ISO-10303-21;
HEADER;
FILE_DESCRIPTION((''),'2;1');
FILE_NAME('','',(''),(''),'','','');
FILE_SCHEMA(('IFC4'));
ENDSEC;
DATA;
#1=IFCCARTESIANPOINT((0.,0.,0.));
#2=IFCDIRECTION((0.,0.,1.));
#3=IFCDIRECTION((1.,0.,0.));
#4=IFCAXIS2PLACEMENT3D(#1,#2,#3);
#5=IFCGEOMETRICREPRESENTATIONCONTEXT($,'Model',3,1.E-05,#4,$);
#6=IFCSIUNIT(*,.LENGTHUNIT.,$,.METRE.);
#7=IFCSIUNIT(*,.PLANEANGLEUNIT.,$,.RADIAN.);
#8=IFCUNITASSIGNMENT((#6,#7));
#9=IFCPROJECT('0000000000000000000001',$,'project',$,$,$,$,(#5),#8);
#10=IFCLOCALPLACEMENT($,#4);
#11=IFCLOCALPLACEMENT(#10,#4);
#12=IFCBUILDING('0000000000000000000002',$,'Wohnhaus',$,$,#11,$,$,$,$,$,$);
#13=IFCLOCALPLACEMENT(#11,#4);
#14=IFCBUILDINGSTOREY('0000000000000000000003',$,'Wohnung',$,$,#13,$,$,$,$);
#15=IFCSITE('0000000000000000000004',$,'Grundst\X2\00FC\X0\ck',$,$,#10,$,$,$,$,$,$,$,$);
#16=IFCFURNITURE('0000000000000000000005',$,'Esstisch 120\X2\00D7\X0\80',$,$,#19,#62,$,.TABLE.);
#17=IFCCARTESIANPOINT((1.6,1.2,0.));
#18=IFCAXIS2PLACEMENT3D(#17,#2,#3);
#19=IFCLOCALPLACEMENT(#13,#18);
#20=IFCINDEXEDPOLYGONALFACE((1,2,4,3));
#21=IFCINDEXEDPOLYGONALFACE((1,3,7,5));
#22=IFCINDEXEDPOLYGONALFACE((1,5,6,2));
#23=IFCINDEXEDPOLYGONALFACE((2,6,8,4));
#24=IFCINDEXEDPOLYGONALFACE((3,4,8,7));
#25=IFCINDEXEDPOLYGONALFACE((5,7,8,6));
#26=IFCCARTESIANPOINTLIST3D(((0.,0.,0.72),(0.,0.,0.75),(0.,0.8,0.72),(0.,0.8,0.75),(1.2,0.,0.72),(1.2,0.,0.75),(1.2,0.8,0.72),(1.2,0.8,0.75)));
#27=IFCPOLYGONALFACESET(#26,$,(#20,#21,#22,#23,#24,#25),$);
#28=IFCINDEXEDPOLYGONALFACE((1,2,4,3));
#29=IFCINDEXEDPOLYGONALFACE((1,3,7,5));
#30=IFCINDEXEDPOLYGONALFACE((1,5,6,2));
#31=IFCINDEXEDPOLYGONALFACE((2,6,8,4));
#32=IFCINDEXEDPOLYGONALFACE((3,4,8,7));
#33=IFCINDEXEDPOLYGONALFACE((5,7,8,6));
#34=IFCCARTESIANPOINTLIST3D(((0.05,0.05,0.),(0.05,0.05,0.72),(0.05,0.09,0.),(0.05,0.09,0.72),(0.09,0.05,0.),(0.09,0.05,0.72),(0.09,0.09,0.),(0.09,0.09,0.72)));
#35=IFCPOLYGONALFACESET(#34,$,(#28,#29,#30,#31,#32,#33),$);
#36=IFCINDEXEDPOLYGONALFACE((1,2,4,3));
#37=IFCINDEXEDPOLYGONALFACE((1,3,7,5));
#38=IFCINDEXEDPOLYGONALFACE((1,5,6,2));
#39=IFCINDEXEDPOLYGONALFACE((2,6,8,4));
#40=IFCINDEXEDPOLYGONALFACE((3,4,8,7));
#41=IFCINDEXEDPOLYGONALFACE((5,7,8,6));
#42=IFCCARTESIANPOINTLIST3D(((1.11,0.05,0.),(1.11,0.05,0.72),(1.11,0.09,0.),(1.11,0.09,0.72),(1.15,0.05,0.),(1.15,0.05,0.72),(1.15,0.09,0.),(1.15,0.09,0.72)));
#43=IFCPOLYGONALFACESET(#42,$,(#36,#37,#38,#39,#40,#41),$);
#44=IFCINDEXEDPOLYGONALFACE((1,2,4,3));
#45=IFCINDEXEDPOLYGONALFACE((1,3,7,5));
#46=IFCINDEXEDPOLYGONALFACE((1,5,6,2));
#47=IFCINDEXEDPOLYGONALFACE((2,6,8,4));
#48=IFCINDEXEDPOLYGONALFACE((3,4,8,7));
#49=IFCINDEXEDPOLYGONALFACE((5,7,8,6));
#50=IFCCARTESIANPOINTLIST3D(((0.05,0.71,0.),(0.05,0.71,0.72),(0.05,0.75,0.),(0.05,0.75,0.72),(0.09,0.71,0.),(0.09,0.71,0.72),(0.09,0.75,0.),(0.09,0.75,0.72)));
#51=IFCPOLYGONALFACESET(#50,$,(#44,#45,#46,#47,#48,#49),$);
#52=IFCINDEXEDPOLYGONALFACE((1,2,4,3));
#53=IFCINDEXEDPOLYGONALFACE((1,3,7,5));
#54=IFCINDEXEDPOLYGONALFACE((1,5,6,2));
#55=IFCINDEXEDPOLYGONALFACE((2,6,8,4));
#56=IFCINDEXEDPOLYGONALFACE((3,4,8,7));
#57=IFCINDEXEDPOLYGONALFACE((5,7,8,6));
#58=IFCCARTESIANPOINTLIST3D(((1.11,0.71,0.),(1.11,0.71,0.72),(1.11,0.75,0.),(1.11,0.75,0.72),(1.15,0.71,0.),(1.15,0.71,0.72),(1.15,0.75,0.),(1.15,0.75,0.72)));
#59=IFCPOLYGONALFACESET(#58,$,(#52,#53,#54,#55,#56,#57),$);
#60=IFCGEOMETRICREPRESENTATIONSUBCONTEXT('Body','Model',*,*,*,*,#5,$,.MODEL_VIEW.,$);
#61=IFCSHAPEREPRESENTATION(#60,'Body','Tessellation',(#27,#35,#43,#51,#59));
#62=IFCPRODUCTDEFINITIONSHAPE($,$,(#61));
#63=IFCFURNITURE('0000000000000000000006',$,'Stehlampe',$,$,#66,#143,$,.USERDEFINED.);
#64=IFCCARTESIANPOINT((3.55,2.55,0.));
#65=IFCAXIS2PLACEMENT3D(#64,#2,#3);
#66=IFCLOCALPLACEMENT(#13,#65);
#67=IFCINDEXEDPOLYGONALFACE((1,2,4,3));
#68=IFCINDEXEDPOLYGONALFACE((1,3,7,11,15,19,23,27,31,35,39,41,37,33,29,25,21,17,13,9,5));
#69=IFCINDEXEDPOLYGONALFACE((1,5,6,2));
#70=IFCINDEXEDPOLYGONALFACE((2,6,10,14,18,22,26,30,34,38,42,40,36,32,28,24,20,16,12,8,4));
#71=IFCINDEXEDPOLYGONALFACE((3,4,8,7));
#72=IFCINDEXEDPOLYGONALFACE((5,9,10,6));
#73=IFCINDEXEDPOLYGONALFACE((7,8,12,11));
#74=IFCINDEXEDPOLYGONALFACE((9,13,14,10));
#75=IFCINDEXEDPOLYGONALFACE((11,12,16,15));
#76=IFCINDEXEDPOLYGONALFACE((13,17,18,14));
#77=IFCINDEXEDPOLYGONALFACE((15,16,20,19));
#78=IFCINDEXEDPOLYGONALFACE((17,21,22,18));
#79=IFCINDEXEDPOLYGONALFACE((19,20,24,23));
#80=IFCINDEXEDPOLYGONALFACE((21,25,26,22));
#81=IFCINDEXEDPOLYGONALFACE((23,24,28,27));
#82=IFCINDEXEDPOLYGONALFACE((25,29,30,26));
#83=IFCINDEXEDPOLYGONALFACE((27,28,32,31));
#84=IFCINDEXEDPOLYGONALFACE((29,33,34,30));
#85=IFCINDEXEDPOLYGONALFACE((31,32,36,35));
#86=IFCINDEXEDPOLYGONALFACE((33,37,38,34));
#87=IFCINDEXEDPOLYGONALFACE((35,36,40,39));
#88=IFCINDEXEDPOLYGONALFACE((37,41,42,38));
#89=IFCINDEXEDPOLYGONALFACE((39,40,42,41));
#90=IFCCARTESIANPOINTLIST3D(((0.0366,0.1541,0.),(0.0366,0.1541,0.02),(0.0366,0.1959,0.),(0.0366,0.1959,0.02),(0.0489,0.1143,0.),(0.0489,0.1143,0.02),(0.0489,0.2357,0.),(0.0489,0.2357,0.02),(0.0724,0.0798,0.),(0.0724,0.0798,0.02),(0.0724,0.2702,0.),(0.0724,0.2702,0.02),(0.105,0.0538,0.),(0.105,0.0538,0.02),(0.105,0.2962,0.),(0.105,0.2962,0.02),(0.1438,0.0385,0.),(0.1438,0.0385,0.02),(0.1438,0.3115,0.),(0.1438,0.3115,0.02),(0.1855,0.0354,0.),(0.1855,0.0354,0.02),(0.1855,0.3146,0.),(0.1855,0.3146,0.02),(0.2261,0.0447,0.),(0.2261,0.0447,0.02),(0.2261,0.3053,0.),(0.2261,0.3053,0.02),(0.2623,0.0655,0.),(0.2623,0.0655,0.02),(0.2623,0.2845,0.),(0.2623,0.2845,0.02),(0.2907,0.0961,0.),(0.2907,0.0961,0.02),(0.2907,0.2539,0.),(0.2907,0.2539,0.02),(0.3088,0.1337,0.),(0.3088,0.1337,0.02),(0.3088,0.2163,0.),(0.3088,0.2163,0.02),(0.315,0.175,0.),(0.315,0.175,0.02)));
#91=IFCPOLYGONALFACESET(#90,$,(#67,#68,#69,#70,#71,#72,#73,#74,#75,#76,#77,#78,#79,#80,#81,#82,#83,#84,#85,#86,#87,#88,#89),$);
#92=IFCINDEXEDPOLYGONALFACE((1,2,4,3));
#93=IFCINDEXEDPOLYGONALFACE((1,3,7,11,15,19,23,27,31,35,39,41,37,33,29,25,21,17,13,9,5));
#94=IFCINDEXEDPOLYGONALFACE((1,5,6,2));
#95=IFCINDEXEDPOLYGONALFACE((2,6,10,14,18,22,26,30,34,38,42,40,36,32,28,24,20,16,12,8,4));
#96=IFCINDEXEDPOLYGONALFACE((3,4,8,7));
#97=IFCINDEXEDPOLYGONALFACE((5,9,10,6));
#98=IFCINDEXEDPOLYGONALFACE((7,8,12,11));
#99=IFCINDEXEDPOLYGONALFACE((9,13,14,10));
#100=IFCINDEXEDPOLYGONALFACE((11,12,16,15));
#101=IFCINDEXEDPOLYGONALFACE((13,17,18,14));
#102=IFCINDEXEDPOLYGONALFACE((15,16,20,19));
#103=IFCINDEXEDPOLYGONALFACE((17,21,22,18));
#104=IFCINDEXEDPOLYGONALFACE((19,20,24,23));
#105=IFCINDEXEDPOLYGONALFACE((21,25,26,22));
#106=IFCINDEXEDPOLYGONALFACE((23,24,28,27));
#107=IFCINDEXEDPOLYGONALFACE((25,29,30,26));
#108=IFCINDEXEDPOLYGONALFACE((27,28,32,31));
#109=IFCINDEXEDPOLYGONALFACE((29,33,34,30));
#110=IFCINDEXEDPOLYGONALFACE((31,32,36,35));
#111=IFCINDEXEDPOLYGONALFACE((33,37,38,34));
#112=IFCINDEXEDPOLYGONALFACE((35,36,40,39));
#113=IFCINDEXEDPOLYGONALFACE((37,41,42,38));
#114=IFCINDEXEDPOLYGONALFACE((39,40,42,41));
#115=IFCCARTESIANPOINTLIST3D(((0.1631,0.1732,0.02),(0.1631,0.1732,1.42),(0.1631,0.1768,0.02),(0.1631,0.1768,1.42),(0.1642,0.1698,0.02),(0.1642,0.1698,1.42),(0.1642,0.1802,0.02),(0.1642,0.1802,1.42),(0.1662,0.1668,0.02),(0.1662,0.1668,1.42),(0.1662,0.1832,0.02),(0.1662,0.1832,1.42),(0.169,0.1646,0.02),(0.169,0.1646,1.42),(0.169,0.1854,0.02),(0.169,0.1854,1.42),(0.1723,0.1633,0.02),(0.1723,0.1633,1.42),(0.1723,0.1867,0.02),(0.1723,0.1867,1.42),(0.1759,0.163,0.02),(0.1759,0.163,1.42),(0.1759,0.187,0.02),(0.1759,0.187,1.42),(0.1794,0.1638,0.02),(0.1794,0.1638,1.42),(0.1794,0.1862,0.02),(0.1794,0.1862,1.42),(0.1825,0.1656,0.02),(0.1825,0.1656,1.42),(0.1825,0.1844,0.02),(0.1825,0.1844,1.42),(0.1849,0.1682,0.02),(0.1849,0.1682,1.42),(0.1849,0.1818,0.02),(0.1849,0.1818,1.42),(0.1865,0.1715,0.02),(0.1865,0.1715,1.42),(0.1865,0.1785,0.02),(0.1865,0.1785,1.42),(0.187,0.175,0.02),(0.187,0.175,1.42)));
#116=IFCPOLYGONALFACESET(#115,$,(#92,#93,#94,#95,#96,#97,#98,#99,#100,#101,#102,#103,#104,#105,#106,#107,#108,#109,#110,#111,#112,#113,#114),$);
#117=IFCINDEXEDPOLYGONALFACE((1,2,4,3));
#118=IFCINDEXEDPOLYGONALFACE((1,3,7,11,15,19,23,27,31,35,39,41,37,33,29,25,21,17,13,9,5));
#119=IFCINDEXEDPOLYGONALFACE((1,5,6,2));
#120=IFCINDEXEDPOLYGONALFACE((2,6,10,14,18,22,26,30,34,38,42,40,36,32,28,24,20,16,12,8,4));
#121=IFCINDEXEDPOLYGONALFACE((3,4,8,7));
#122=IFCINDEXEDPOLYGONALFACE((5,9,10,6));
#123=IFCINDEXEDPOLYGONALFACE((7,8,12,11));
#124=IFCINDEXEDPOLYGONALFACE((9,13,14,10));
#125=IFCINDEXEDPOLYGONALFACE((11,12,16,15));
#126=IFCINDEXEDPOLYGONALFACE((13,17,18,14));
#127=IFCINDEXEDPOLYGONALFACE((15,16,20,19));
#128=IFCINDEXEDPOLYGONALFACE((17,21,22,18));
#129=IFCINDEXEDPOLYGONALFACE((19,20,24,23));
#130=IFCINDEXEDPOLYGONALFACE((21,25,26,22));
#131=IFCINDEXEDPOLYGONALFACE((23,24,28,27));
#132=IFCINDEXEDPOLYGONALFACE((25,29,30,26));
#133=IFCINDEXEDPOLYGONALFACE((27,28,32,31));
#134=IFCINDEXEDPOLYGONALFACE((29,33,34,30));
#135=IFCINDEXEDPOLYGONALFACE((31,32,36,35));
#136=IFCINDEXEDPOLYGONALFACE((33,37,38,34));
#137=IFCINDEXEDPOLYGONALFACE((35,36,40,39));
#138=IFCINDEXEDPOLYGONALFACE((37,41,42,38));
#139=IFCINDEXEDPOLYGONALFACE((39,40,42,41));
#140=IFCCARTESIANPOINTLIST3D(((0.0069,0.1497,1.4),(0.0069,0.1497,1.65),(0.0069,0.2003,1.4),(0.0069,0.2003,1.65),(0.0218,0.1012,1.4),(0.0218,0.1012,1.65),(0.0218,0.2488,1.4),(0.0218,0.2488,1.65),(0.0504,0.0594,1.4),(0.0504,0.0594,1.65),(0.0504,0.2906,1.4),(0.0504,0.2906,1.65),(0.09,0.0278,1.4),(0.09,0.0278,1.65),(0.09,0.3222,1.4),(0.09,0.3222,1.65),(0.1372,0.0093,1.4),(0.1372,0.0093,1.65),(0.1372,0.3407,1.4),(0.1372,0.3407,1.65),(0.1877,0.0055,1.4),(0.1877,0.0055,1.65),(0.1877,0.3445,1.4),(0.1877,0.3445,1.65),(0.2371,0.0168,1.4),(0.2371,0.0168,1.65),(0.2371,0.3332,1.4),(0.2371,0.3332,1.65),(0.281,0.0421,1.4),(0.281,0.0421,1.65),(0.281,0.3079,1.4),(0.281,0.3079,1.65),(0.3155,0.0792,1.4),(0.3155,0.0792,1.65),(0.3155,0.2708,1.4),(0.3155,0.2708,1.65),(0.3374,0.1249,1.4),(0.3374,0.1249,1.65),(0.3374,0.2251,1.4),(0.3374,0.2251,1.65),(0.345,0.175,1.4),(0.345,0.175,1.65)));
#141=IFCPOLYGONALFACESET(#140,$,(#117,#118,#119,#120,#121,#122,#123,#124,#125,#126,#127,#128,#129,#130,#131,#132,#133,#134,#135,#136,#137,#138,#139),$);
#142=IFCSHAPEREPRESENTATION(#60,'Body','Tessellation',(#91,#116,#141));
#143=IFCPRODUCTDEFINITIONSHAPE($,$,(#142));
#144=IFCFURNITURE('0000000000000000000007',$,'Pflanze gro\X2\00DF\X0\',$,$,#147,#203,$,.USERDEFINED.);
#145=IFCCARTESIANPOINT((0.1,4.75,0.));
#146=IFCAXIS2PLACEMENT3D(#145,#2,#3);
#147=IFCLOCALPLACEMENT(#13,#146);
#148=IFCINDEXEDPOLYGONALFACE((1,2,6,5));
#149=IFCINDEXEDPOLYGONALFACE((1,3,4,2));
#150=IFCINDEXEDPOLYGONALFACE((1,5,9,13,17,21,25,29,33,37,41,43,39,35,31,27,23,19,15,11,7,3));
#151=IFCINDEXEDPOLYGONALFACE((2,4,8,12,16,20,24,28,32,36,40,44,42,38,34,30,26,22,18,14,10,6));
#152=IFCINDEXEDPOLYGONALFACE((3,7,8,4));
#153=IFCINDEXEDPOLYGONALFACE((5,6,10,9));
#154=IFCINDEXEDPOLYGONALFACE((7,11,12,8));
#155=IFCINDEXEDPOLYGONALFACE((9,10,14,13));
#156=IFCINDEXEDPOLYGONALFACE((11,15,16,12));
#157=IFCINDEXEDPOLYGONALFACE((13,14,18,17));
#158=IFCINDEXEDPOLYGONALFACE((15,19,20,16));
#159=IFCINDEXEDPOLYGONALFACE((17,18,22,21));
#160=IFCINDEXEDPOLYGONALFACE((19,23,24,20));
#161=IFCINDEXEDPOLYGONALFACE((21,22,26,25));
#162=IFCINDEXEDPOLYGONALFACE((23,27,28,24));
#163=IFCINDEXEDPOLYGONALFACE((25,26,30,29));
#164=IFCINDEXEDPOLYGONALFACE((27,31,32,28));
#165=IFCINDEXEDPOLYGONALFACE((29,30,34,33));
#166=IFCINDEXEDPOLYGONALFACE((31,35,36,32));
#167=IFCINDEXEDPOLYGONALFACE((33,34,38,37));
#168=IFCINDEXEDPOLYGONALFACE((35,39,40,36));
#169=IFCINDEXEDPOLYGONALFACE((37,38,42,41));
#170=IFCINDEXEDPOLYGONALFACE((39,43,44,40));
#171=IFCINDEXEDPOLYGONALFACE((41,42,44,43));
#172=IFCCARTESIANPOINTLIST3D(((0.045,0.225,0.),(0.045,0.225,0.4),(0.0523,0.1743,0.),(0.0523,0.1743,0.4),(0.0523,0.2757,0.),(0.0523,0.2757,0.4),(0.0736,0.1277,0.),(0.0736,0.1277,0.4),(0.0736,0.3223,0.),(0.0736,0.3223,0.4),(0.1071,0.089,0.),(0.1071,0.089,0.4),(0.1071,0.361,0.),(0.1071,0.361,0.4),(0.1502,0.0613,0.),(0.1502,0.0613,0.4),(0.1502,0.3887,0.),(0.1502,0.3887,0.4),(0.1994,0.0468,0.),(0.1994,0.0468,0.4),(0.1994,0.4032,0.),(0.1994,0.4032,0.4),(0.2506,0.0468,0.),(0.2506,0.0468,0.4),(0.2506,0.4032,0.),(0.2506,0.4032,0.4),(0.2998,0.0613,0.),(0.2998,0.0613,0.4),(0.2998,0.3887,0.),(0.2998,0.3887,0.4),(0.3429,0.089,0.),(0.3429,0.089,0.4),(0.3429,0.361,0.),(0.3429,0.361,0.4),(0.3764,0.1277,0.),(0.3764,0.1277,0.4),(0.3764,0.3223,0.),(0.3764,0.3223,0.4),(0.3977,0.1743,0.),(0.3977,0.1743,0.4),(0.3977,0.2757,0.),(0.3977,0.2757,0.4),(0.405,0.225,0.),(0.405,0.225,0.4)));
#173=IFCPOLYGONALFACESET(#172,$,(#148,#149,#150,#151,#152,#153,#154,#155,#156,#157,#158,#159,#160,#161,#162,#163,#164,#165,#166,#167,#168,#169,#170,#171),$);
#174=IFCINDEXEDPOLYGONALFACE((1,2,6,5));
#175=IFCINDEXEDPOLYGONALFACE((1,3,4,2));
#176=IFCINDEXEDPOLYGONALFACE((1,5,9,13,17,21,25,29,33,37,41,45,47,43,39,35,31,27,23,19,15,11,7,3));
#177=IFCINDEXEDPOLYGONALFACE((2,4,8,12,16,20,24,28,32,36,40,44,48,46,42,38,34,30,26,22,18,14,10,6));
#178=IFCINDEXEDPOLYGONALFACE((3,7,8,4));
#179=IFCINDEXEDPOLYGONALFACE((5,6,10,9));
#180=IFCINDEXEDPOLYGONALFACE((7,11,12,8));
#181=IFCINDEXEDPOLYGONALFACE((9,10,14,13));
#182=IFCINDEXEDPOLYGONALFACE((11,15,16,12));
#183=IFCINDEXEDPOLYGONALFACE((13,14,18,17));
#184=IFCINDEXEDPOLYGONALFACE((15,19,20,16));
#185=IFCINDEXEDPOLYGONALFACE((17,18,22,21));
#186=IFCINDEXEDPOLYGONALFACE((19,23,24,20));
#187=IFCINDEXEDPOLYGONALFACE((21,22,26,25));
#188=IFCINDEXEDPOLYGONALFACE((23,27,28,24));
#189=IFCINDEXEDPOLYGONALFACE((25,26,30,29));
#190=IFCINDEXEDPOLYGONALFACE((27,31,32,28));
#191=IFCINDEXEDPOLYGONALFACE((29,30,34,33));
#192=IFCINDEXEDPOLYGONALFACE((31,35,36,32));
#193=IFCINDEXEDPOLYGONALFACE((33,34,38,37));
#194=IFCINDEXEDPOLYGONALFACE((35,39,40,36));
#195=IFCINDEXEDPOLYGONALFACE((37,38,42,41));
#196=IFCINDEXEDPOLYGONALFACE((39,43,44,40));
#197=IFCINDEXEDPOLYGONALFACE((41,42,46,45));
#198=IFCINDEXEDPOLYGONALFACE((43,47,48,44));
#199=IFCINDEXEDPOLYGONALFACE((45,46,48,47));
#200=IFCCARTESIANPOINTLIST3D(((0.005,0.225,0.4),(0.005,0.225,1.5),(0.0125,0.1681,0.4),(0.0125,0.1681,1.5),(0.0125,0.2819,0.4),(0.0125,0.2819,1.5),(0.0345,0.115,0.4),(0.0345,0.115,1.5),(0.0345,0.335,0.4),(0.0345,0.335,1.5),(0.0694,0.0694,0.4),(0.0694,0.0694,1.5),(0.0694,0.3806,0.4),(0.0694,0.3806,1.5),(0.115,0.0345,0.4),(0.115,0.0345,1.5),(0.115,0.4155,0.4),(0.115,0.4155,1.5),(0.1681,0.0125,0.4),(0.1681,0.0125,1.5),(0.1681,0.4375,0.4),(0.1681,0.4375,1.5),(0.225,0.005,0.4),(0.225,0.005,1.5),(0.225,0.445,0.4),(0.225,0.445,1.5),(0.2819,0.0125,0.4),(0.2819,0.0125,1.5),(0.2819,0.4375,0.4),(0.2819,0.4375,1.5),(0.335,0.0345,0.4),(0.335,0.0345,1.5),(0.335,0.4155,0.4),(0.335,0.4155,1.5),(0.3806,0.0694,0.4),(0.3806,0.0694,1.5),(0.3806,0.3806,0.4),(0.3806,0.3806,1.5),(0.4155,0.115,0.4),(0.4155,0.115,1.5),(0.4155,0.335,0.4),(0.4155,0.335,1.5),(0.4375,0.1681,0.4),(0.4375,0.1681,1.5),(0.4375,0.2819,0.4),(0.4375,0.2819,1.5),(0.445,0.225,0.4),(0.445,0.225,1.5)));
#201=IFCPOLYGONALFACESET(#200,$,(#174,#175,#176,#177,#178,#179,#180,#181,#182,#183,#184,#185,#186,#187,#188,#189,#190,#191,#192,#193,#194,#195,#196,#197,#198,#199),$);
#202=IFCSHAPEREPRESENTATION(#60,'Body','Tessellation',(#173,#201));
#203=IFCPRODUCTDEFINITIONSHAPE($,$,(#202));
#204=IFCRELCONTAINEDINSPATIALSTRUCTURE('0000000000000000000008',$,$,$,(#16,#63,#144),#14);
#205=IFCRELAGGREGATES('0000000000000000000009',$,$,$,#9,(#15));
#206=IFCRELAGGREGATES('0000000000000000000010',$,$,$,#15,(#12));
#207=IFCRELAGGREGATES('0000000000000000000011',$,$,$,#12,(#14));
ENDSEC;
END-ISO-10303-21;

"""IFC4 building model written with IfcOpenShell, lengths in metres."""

from ifc_helpers import new_model, si_unit, frame, frame_2d, origin, origin_with_axes, place, context, subcontext, project, spatial, rectangle, circle, extrude, element, save


model = new_model("IFC4")

# Units and contexts
model_context = context("Model", 3, precision=1e-05, world=origin_with_axes())
body_context = subcontext(model_context, "Body", "Model", "MODEL_VIEW")
ifc_project = project(units=[si_unit("LENGTHUNIT", "METRE"), si_unit("PLANEANGLEUNIT", "RADIAN")], contexts=[model_context])

# Site, building, storey
site_placement = place(None, origin_with_axes())
site = spatial("IfcSite", under=ifc_project, at=site_placement, Name="Grundstück")
building_placement = place(site_placement, origin_with_axes())
building = spatial("IfcBuilding", under=site, at=building_placement, Name="Wohnhaus")
storey_placement = place(building_placement, origin_with_axes())
storey = spatial("IfcBuildingStorey", under=building, at=storey_placement, Name="Wohnung")

# Furniture
furniture_1_placement = place(storey_placement, frame((1.6, 1.2, 0.0), z_axis=(0.0, 0.0, 1.0), x_axis=(1.0, 0.0, 0.0)))
element("IfcFurniture", 1, at=furniture_1_placement, inside=storey, Name="Esstisch 120×80", PredefinedType="TABLE", context=body_context, shape_type="SweptSolid", body=[
    extrude(rectangle(XDim=1.2, YDim=0.8, at=frame_2d((0.6, 0.4))), frame((0.0, 0.0, 0.72)), (0.0, 0.0, 1.0), 0.03),
    extrude(rectangle(XDim=0.04, YDim=0.04, at=frame_2d((0.07, 0.07))), origin(), (0.0, 0.0, 1.0), 0.72),
    extrude(rectangle(XDim=0.04, YDim=0.04, at=frame_2d((1.13, 0.07))), origin(), (0.0, 0.0, 1.0), 0.72),
    extrude(rectangle(XDim=0.04, YDim=0.04, at=frame_2d((0.07, 0.73))), origin(), (0.0, 0.0, 1.0), 0.72),
    extrude(rectangle(XDim=0.04, YDim=0.04, at=frame_2d((1.13, 0.73))), origin(), (0.0, 0.0, 1.0), 0.72),
])
furniture_2_placement = place(storey_placement, frame((3.55, 2.55, 0.0), z_axis=(0.0, 0.0, 1.0), x_axis=(1.0, 0.0, 0.0)))
element("IfcFurniture", 2, at=furniture_2_placement, inside=storey, Name="Stehlampe", PredefinedType="USERDEFINED", context=body_context, shape_type="SweptSolid", body=[
    extrude(circle(Radius=0.14, at=frame_2d((0.175, 0.175))), origin(), (0.0, 0.0, 1.0), 0.02),
    extrude(circle(Radius=0.012, at=frame_2d((0.175, 0.175))), frame((0.0, 0.0, 0.02)), (0.0, 0.0, 1.0), 1.4),
    extrude(circle(Radius=0.17, at=frame_2d((0.175, 0.175))), frame((0.0, 0.0, 1.4)), (0.0, 0.0, 1.0), 0.25),
])
furniture_3_placement = place(storey_placement, frame((0.1, 4.75, 0.0), z_axis=(0.0, 0.0, 1.0), x_axis=(1.0, 0.0, 0.0)))
element("IfcFurniture", 3, at=furniture_3_placement, inside=storey, Name="Pflanze groß", PredefinedType="USERDEFINED", context=body_context, shape_type="SweptSolid", body=[
    extrude(circle(Radius=0.18, at=frame_2d((0.225, 0.225))), origin(), (0.0, 0.0, 1.0), 0.4),
    extrude(circle(Radius=0.22, at=frame_2d((0.225, 0.225))), frame((0.0, 0.0, 0.4)), (0.0, 0.0, 1.0), 1.1),
])

save(model, "model.ifc")
